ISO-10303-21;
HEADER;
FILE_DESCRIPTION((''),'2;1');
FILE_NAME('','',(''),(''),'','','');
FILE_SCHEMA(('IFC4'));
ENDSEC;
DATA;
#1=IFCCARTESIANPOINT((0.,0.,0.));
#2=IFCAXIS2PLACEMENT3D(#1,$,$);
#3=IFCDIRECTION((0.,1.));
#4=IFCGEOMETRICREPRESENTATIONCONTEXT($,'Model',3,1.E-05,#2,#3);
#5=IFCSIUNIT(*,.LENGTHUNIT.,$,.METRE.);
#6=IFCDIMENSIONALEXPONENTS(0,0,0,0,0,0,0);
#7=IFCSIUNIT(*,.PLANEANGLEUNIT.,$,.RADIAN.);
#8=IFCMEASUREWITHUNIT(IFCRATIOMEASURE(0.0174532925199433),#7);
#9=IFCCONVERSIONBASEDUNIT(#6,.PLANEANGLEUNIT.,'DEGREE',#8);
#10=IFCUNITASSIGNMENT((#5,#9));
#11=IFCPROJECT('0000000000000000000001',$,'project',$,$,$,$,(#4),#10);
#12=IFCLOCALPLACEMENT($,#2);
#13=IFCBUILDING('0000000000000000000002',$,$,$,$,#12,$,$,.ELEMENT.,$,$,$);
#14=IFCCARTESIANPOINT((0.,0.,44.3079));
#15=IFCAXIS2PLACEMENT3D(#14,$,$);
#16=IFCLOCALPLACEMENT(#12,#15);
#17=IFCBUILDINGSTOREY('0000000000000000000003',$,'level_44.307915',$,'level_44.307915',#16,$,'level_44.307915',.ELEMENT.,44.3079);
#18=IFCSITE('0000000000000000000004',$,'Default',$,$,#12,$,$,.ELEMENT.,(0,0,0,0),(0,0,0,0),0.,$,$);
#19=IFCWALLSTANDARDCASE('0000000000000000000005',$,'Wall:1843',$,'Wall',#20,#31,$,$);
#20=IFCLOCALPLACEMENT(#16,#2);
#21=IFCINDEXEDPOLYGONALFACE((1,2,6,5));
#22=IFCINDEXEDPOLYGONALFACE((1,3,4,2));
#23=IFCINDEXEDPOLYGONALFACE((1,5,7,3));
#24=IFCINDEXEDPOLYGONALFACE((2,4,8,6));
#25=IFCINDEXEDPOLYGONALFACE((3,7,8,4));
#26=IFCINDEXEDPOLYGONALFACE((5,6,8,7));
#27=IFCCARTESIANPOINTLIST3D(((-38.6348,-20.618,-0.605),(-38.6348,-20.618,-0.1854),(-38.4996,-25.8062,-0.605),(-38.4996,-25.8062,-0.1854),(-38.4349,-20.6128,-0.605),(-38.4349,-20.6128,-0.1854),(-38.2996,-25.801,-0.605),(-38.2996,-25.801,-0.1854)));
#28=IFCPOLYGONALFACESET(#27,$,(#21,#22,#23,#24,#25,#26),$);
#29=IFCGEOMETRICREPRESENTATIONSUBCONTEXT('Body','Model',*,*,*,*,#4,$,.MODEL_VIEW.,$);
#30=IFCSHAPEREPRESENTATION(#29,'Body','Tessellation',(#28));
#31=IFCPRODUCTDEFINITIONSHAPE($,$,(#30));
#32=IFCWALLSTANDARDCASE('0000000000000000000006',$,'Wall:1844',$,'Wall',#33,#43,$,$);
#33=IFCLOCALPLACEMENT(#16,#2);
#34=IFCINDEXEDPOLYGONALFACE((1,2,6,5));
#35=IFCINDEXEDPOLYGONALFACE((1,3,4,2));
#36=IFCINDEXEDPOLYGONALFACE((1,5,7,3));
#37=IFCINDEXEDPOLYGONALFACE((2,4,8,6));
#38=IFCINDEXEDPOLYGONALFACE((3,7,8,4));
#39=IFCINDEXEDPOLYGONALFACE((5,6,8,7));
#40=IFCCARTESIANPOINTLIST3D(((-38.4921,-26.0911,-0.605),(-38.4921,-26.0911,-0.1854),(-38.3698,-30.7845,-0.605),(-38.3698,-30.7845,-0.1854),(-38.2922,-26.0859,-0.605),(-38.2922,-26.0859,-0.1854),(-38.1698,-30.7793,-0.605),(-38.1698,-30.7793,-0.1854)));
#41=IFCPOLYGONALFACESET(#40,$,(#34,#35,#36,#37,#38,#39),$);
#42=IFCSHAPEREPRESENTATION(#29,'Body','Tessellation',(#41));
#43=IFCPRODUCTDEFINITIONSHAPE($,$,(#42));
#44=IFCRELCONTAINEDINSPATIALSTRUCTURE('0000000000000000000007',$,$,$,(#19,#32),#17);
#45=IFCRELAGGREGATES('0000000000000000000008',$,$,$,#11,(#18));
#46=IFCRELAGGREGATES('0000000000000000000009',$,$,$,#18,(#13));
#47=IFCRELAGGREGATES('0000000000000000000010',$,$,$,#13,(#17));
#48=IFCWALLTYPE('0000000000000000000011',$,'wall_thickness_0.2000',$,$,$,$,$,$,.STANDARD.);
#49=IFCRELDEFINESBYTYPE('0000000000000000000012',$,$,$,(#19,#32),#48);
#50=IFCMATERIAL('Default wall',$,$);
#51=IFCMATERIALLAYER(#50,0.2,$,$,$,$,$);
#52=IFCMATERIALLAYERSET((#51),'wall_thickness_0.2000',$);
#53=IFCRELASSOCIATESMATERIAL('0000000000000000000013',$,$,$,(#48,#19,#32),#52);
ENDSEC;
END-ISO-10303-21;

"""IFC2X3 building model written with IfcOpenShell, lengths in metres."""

from ifc_helpers import new_model, entity, si_unit, converted_unit, direction, frame, origin, place, context, subcontext, project, spatial, polyline, outline, extrude, material, layer, layer_set, layer_usage, type_object, element, save


model = new_model("IFC2X3")

# Units and contexts
model_context = context("Model", 3, precision=1e-05, world=origin(), true_north=direction((0.0, 1.0)))
body_context = subcontext(model_context, "Body", "Model", "MODEL_VIEW")
ifc_project = project(units=[si_unit("LENGTHUNIT", "METRE"), converted_unit("PLANEANGLEUNIT", "DEGREE", entity("IfcRatioMeasure", 0.0174532925199433), si_unit("PLANEANGLEUNIT", "RADIAN"), dimensions=[0, 0, 0, 0, 0, 0, 0])], contexts=[model_context])

# Site, building, storey
placement_1 = place(None, origin())
site = spatial("IfcSite", under=ifc_project, at=placement_1, Name="Default", CompositionType="ELEMENT", RefLatitude=(0, 0, 0, 0), RefLongitude=(0, 0, 0, 0), RefElevation=0.0)
building = spatial("IfcBuilding", under=site, at=placement_1, CompositionType="ELEMENT")
storey_placement = place(placement_1, frame((0.0, 0.0, 44.3079)))
storey = spatial("IfcBuildingStorey", under=building, at=storey_placement, Name="level_44.307915", ObjectType="level_44.307915", LongName="level_44.307915", CompositionType="ELEMENT", Elevation=44.3079)

# Shared definitions
ifc_material_1 = material(Name="Default wall")
ifc_layer = layer(ifc_material_1, 0.2)
ifc_layer_set = layer_set([ifc_layer], Name="wall_thickness_0.2000")
ifc_layer_usage = layer_usage(ifc_layer_set, "AXIS2", "POSITIVE", -0.1)
wall_type = type_object("IfcWallType", Name="wall_thickness_0.2000", PredefinedType="STANDARD", material=ifc_layer_set)

# Walls
placement_2 = place(placement_1, frame((0.0, 0.0, 43.7029)))
wall_1_placement = place(placement_2, frame((-38.5349, -20.6154, 0.0), z_axis=(0.0, 0.0, 1.0), x_axis=(0.026063, -0.99966, 0.0)))
element("IfcWallStandardCase", 1, at=wall_1_placement, inside=storey, type_object=wall_type, material=ifc_layer_usage, Name="Wall:1843", ObjectType="Wall", context=body_context, shape_type="SweptSolid", body=[
    extrude(outline(polyline([(5.19, -0.1), (5.19, 0.1), (0.0, 0.1), (0.0, -0.1), (5.19, -0.1)])), origin(), (0.0, 0.0, 1.0), 0.4196),
])
placement_3 = place(placement_1, frame((0.0, 0.0, 43.7029)))
wall_2_placement = place(placement_3, frame((-38.3922, -26.0885, 0.0), z_axis=(0.0, 0.0, 1.0), x_axis=(0.026063, -0.99966, 0.0)))
element("IfcWallStandardCase", 2, at=wall_2_placement, inside=storey, type_object=wall_type, material=ifc_layer_usage, Name="Wall:1844", ObjectType="Wall", context=body_context, shape_type="SweptSolid", body=[
    extrude(outline(polyline([(4.695, -0.1), (4.695, 0.1), (0.0, 0.1), (0.0, -0.1), (4.695, -0.1)])), origin(), (0.0, 0.0, 1.0), 0.4196),
])

save(model, "model.ifc")
